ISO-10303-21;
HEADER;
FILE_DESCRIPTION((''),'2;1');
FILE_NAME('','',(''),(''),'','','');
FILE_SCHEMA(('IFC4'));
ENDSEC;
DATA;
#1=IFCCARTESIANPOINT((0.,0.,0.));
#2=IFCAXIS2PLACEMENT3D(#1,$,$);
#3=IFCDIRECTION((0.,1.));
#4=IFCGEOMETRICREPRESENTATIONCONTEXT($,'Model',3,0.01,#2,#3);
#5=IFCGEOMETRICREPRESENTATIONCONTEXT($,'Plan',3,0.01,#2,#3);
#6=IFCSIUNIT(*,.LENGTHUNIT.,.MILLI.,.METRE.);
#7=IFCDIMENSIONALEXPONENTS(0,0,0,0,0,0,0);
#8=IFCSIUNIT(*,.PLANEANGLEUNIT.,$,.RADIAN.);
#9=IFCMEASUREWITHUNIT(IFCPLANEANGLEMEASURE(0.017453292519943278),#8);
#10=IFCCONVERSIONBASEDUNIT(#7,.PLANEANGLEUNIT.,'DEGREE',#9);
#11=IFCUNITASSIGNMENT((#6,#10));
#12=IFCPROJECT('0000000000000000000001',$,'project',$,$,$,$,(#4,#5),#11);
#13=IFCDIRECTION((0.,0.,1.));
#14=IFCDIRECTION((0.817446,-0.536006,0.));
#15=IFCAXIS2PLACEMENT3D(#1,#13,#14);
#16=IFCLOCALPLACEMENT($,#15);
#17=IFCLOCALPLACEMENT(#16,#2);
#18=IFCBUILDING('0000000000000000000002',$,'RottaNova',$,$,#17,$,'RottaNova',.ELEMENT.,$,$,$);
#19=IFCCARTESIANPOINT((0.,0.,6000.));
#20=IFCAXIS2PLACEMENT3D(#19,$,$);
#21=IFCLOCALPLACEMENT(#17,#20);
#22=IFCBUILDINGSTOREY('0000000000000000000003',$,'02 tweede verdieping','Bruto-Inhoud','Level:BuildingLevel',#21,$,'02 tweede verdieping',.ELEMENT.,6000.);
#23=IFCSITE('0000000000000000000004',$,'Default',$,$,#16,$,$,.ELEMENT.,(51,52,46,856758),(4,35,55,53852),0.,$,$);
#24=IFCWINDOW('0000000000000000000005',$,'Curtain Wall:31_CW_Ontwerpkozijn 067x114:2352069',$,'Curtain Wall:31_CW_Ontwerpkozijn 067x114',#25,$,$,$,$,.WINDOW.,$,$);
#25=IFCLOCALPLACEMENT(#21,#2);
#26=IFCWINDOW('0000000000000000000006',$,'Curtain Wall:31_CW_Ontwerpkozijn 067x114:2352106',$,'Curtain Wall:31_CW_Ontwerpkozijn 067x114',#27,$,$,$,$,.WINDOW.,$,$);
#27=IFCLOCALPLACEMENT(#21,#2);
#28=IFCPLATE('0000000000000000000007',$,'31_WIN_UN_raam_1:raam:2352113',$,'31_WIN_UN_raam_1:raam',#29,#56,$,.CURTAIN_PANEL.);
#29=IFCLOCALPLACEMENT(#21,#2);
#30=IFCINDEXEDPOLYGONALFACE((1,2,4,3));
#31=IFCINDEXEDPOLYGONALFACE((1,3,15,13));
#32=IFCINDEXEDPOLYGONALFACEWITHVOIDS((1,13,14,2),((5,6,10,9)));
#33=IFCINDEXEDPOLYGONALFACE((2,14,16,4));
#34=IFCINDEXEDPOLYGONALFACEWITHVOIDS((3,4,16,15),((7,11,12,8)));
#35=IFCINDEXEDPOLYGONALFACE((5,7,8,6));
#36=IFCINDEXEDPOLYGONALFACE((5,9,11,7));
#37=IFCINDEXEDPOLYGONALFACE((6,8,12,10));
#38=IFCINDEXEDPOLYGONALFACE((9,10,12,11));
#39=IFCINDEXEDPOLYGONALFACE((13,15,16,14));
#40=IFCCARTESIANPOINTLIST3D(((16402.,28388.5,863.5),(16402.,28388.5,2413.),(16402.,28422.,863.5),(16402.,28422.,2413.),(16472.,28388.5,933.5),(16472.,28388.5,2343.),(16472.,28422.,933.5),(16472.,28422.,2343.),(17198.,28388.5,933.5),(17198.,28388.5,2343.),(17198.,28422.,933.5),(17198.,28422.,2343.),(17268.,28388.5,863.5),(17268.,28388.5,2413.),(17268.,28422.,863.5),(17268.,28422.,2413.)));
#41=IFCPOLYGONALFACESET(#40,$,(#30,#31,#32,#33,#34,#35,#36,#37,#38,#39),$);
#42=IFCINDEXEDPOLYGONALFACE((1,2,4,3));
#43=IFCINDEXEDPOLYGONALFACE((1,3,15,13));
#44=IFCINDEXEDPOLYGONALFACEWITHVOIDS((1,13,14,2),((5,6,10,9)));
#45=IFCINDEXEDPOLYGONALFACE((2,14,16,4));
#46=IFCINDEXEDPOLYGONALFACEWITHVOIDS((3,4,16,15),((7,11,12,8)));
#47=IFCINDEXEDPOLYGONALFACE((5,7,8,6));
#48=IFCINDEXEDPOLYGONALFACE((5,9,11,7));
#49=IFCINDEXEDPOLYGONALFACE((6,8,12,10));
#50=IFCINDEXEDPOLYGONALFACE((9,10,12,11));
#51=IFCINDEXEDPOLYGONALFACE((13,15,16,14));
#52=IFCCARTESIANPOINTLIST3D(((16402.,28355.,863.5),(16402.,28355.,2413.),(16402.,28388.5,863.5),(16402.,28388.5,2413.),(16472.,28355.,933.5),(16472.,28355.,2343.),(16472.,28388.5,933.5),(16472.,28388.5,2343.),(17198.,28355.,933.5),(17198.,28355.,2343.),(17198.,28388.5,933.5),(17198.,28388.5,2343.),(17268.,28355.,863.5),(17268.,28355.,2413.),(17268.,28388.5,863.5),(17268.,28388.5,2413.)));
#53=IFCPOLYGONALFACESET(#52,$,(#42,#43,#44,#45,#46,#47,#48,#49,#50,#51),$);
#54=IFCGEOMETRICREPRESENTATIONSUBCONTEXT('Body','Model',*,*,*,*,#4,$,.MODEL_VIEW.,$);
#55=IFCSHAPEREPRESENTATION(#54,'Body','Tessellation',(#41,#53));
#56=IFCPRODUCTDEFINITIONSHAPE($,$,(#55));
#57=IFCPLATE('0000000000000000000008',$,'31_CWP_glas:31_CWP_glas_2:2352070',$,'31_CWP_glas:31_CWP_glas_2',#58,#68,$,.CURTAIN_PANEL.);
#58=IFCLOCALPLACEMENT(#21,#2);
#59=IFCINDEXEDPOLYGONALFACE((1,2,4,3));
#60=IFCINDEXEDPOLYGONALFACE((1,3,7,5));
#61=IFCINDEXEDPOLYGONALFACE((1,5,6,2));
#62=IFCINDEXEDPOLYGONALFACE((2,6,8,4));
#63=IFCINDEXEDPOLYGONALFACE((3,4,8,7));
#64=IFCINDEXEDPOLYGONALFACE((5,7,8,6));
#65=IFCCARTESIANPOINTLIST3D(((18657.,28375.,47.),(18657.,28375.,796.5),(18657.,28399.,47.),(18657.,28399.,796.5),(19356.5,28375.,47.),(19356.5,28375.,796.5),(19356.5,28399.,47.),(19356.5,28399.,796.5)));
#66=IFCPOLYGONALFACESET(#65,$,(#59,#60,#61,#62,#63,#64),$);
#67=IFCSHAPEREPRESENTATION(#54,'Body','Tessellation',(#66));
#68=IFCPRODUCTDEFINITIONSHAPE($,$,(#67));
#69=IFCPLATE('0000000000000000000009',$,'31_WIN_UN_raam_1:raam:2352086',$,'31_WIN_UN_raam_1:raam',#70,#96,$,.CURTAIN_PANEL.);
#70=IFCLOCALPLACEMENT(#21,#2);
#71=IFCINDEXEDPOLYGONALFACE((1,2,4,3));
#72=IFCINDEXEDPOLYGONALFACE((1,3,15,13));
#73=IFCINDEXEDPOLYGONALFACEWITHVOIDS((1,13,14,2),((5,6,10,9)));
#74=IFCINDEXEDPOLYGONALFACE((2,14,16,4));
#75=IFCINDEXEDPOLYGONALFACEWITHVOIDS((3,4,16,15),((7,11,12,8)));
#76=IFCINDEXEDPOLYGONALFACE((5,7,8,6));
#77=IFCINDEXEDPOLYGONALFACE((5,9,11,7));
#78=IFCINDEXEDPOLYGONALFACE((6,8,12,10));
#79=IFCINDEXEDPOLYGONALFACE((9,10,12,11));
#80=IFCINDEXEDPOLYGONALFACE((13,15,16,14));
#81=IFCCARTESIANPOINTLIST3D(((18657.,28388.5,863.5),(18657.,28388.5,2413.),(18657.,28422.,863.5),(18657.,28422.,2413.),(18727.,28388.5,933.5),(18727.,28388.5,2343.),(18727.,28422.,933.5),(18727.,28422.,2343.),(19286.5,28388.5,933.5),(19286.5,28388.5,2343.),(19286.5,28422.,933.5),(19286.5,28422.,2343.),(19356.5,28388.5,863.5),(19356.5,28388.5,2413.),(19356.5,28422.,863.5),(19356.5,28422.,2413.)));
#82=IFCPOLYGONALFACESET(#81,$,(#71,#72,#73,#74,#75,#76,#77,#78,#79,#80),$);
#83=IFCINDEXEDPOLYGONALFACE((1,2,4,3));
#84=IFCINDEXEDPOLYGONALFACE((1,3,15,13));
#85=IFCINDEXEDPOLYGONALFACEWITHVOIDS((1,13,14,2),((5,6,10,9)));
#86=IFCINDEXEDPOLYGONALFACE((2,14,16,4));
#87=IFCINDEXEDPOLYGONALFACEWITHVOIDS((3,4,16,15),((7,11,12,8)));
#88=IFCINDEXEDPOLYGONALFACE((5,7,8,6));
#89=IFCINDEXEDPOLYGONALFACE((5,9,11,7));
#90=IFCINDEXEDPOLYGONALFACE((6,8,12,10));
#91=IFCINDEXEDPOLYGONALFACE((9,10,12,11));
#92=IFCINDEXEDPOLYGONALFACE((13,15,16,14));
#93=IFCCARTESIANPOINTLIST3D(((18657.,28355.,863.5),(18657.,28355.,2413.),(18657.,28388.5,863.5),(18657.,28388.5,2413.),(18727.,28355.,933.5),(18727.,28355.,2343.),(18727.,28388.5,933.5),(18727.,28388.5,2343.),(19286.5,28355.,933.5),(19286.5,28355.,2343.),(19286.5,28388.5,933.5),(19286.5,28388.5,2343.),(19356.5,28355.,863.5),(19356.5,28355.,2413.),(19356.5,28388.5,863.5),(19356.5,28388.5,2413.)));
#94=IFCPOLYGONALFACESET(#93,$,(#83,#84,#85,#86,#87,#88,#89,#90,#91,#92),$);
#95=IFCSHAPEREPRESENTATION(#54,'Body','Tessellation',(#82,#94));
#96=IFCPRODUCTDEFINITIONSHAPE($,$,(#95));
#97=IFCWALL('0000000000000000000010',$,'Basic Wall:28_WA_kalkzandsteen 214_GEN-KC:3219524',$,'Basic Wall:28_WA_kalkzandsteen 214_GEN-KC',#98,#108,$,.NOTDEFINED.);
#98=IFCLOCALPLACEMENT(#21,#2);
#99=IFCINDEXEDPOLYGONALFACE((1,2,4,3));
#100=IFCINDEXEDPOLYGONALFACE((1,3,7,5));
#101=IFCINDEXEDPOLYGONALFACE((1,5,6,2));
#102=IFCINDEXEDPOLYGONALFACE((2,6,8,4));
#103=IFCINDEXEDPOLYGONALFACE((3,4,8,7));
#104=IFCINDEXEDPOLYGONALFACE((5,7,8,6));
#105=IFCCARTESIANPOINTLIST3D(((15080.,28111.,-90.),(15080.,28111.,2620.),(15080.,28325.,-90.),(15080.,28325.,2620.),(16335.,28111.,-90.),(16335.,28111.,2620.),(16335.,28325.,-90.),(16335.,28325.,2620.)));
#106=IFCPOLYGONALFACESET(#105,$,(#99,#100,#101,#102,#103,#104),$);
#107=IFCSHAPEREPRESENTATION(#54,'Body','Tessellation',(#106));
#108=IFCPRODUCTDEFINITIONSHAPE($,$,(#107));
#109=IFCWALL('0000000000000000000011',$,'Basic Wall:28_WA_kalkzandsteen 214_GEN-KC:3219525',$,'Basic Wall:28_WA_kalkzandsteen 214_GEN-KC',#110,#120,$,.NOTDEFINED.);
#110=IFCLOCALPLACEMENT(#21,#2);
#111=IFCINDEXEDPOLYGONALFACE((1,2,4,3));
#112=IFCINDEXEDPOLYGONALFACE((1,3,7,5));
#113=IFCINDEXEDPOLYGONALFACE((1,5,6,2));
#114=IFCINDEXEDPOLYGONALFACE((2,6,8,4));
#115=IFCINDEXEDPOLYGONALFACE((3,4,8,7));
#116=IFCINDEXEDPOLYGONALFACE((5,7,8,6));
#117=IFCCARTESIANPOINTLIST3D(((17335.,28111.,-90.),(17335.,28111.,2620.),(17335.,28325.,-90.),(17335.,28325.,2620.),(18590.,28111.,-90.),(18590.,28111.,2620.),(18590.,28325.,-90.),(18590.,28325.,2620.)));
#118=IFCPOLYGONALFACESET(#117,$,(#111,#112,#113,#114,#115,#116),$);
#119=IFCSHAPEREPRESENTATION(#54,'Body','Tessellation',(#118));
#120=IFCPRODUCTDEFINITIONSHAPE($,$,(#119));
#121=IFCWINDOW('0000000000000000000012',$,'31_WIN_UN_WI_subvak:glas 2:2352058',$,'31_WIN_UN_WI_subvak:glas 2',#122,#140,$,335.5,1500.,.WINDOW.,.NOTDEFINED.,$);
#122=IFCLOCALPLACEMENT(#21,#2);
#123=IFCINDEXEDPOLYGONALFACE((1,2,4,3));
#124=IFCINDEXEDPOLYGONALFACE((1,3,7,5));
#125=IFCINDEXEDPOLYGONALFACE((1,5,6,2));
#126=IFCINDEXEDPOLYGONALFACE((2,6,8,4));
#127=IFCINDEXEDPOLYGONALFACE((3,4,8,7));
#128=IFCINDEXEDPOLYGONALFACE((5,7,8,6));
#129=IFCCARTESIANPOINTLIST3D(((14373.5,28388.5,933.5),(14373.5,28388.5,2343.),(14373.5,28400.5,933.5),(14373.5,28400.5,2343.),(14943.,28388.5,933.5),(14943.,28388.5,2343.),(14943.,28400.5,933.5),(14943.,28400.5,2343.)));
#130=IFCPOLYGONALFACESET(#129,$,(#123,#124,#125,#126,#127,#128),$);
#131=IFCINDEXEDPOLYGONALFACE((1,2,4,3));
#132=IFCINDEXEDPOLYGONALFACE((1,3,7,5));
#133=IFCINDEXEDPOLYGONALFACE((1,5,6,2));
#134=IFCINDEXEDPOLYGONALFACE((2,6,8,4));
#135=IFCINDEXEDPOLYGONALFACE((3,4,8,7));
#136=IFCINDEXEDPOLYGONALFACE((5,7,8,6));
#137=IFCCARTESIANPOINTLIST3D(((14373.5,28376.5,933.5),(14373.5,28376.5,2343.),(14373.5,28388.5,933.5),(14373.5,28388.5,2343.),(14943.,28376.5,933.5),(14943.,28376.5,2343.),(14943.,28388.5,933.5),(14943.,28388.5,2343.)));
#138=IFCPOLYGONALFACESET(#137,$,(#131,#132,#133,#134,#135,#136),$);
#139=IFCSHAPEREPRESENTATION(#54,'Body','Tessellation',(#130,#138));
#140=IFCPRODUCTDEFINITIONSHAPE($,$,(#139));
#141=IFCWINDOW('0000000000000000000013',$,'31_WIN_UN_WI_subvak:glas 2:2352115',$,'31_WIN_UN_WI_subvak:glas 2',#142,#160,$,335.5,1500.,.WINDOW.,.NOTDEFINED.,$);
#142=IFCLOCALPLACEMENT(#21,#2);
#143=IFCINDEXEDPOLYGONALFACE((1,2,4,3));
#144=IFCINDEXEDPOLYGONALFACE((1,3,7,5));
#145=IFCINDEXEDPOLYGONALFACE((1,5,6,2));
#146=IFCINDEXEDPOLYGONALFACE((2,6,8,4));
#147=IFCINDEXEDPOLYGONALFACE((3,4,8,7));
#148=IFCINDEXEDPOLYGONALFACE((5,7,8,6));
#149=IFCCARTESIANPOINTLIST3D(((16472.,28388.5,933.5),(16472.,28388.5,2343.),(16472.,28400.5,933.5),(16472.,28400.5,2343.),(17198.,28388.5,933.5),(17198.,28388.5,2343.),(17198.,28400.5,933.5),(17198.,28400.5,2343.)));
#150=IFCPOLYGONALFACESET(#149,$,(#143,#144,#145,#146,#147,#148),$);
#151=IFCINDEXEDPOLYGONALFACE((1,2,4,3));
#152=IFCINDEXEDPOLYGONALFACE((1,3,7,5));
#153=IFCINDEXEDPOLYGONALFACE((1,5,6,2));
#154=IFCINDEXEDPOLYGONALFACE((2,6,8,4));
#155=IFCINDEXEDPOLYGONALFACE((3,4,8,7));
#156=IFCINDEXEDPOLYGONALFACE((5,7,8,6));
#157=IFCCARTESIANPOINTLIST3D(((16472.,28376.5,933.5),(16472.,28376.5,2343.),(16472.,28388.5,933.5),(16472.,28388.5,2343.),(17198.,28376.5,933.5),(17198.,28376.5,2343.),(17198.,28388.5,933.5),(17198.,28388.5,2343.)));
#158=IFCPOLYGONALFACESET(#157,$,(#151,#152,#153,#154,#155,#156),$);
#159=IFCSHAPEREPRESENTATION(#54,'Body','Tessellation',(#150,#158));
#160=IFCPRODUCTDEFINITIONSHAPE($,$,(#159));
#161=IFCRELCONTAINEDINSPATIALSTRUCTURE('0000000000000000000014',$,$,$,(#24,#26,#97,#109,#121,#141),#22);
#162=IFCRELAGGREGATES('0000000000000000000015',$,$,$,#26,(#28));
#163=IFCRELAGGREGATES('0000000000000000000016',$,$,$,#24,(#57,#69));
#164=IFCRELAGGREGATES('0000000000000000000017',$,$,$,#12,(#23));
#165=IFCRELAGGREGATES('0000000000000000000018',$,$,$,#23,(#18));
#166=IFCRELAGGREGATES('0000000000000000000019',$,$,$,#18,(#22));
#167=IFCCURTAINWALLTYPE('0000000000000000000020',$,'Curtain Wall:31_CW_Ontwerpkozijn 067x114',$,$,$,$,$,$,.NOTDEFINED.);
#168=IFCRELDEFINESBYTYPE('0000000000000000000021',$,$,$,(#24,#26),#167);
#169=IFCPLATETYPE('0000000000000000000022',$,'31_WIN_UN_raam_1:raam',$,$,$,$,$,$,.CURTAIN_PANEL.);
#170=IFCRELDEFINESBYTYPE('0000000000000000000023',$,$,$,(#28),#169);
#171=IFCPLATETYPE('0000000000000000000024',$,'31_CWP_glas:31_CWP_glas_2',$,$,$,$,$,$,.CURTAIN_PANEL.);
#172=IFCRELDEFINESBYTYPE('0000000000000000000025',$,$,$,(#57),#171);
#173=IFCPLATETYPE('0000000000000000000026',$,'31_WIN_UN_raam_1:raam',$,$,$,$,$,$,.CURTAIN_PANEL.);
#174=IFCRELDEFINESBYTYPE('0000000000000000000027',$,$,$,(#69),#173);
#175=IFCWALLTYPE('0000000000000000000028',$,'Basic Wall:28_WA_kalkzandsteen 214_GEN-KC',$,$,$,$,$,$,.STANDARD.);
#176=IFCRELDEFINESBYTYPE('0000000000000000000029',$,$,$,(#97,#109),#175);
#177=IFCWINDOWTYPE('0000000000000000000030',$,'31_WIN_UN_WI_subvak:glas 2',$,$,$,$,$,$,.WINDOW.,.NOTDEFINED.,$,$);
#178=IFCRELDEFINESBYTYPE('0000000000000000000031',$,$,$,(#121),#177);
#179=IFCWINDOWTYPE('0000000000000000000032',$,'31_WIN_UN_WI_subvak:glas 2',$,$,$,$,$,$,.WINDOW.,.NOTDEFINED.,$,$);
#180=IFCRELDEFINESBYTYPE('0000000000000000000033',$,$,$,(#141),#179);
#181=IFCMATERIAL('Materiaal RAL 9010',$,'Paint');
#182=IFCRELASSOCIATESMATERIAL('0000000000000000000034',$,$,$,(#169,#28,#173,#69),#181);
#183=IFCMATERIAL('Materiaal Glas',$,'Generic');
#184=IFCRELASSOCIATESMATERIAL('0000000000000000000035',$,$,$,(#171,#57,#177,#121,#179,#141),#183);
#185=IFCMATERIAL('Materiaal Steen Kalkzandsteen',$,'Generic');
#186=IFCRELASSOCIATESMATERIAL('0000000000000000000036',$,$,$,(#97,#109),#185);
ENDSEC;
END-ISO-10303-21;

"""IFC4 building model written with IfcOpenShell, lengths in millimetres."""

from ifc_helpers import new_model, entity, si_unit, converted_unit, direction, frame, origin, place, context, subcontext, project, spatial, indexed_curve, outline, extrude, source, transform, mapped, material, type_object, type_shapes, element, aggregate, save


model = new_model("IFC4")

# Units and contexts
model_context = context("Model", 3, precision=0.01, world=origin(), true_north=direction((0.0, 1.0)))
plan_context = context("Plan", 3, precision=0.01, world=origin(), true_north=direction((0.0, 1.0)))
body_context = subcontext(model_context, "Body", "Model", "MODEL_VIEW")
ifc_project = project(units=[si_unit("LENGTHUNIT", "METRE", prefix="MILLI"), converted_unit("PLANEANGLEUNIT", "DEGREE", entity("IfcPlaneAngleMeasure", 0.017453292519943278), si_unit("PLANEANGLEUNIT", "RADIAN"), dimensions=[0, 0, 0, 0, 0, 0, 0])], contexts=[model_context, plan_context])

# Site, building, storey
site_placement = place(None, frame((0.0, 0.0, 0.0), z_axis=(0.0, 0.0, 1.0), x_axis=(0.817446, -0.536006, 0.0)))
site = spatial("IfcSite", under=ifc_project, at=site_placement, Name="Default", CompositionType="ELEMENT", RefLatitude=(51, 52, 46, 856758), RefLongitude=(4, 35, 55, 53852), RefElevation=0.0)
building_placement = place(site_placement, origin())
building = spatial("IfcBuilding", under=site, at=building_placement, Name="RottaNova", LongName="RottaNova", CompositionType="ELEMENT")
storey_placement = place(building_placement, frame((0.0, 0.0, 6000.0)))
storey = spatial("IfcBuildingStorey", under=building, at=storey_placement, Name="02 tweede verdieping", Description="Bruto-Inhoud", ObjectType="Level:BuildingLevel", LongName="02 tweede verdieping", CompositionType="ELEMENT", Elevation=6000.0)

# Shared definitions
curtain_wall_type = type_object("IfcCurtainWallType", Name="Curtain Wall:31_CW_Ontwerpkozijn 067x114", PredefinedType="NOTDEFINED")

# Window
window_1_placement = place(storey_placement, frame((0.0, 0.0, -6000.0)))
window_1 = element("IfcWindow", 1, at=window_1_placement, inside=storey, type_object=curtain_wall_type, Name="Curtain Wall:31_CW_Ontwerpkozijn 067x114:2352069", ObjectType="Curtain Wall:31_CW_Ontwerpkozijn 067x114", PredefinedType="WINDOW")

# Window
window_2_placement = place(storey_placement, frame((0.0, 0.0, -6000.0)))
window_2 = element("IfcWindow", 2, at=window_2_placement, inside=storey, type_object=curtain_wall_type, Name="Curtain Wall:31_CW_Ontwerpkozijn 067x114:2352106", ObjectType="Curtain Wall:31_CW_Ontwerpkozijn 067x114", PredefinedType="WINDOW")

# Plates
ifc_material_1 = material(Name="Materiaal Glas", Category="Generic")
ifc_material_2 = material(Name="Materiaal RAL 9010", Category="Paint")
plate_type_1 = type_object("IfcPlateType", Name="31_WIN_UN_raam_1:raam", PredefinedType="CURTAIN_PANEL", material=ifc_material_2)
shared_shape_1 = source(origin(), body_context, "Body", "SweptSolid", [
    extrude(outline(indexed_curve([(-433.0, -774.7), (433.0, -774.7), (433.0, 774.7), (-433.0, 774.7), (-433.0, -774.7)], self_intersect=False), holes=[indexed_curve([(-363.0, 704.7), (363.0, 704.7), (363.0, -704.8), (-363.0, -704.8), (-363.0, 704.7)], self_intersect=False)]), frame((0.0, -92.0, 774.8), z_axis=(0.0, 1.0, 0.0), x_axis=(1.0, 0.0, 0.0)), (0.0, 0.0, 1.0), 33.5),
    extrude(outline(indexed_curve([(-433.0, -774.7), (433.0, -774.7), (433.0, 774.7), (-433.0, 774.7), (-433.0, -774.7)], self_intersect=False), holes=[indexed_curve([(-363.0, 704.7), (363.0, 704.7), (363.0, -704.8), (-363.0, -704.8), (-363.0, 704.7)], self_intersect=False)]), frame((0.0, -58.5, 774.8), z_axis=(0.0, 1.0, 0.0), x_axis=(1.0, 0.0, 0.0)), (0.0, 0.0, 1.0), 33.5),
])
type_shapes(plate_type_1, [shared_shape_1])
plate_1_placement = place(window_2_placement, frame((16835.0, 28330.0, 6863.5), z_axis=(0.0, 0.0, 1.0), x_axis=(-1.0, 0.0, 0.0)))
plate_1 = element("IfcPlate", 3, at=plate_1_placement, type_object=plate_type_1, material=ifc_material_2, Name="31_WIN_UN_raam_1:raam:2352113", ObjectType="31_WIN_UN_raam_1:raam", PredefinedType="CURTAIN_PANEL", context=body_context, shape_type="MappedRepresentation", body=[
    mapped(shared_shape_1, transform((0.0, 0.0, 0.0), scale=1.0)),
])
aggregate(window_2, [plate_1])
plate_type_2 = type_object("IfcPlateType", Name="31_CWP_glas:31_CWP_glas_2", PredefinedType="CURTAIN_PANEL", material=ifc_material_1)
shared_shape_2 = source(origin(), body_context, "Body", "SweptSolid", [
    extrude(outline(indexed_curve([(-12.0, -349.8), (12.0, -349.8), (12.0, 349.8), (-12.0, 349.8), (-12.0, -349.8)], self_intersect=False)), frame((0.0, 57.0, 0.0), z_axis=(0.0, 0.0, 1.0), x_axis=(0.0, 1.0, 0.0)), (0.0, 0.0, 1.0), 749.5),
])
type_shapes(plate_type_2, [shared_shape_2])
plate_2_placement = place(window_1_placement, frame((19006.8, 28330.0, 6047.0)))
plate_2 = element("IfcPlate", 4, at=plate_2_placement, type_object=plate_type_2, material=ifc_material_1, Name="31_CWP_glas:31_CWP_glas_2:2352070", ObjectType="31_CWP_glas:31_CWP_glas_2", PredefinedType="CURTAIN_PANEL", context=body_context, shape_type="MappedRepresentation", body=[
    mapped(shared_shape_2, transform((0.0, 0.0, 0.0), scale=1.0)),
])
plate_type_3 = type_object("IfcPlateType", Name="31_WIN_UN_raam_1:raam", PredefinedType="CURTAIN_PANEL", material=ifc_material_2)
shared_shape_3 = source(origin(), body_context, "Body", "SweptSolid", [
    extrude(outline(indexed_curve([(-349.7, -774.8), (349.7, -774.8), (349.7, 774.8), (-349.7, 774.8), (-349.7, -774.8)], self_intersect=False), holes=[indexed_curve([(-279.7, 704.8), (279.7, 704.8), (279.7, -704.8), (-279.7, -704.8), (-279.7, 704.8)], self_intersect=False)]), frame((0.0, 58.5, 774.8), z_axis=(0.0, 1.0, 0.0), x_axis=(1.0, 0.0, 0.0)), (0.0, 0.0, 1.0), 33.5),
    extrude(outline(indexed_curve([(-349.7, -774.8), (349.7, -774.8), (349.7, 774.8), (-349.7, 774.8), (-349.7, -774.8)], self_intersect=False), holes=[indexed_curve([(-279.7, 704.7), (279.7, 704.7), (279.7, -704.8), (-279.7, -704.8), (-279.7, 704.7)], self_intersect=False)]), frame((0.0, 25.0, 774.8), z_axis=(0.0, 1.0, 0.0), x_axis=(1.0, 0.0, 0.0)), (0.0, 0.0, 1.0), 33.5),
])
type_shapes(plate_type_3, [shared_shape_3])
plate_3_placement = place(window_1_placement, frame((19006.8, 28330.0, 6863.5)))
plate_3 = element("IfcPlate", 5, at=plate_3_placement, type_object=plate_type_3, material=ifc_material_2, Name="31_WIN_UN_raam_1:raam:2352086", ObjectType="31_WIN_UN_raam_1:raam", PredefinedType="CURTAIN_PANEL", context=body_context, shape_type="MappedRepresentation", body=[
    mapped(shared_shape_3, transform((0.0, 0.0, 0.0), scale=1.0)),
])
aggregate(window_1, [plate_2, plate_3])

# Walls
ifc_material_3 = material(Name="Materiaal Steen Kalkzandsteen", Category="Generic")
wall_type = type_object("IfcWallType", Name="Basic Wall:28_WA_kalkzandsteen 214_GEN-KC", PredefinedType="STANDARD")
wall_1_placement = place(storey_placement, frame((15080.0, 28218.0, -90.0)))
element("IfcWall", 6, at=wall_1_placement, inside=storey, type_object=wall_type, material=ifc_material_3, Name="Basic Wall:28_WA_kalkzandsteen 214_GEN-KC:3219524", ObjectType="Basic Wall:28_WA_kalkzandsteen 214_GEN-KC", PredefinedType="NOTDEFINED", context=body_context, shape_type="SweptSolid", body=[
    extrude(outline(indexed_curve([(1255.0, 107.0), (0.0, 107.0), (0.0, -107.0), (1255.0, -107.0), (1255.0, 107.0)], self_intersect=False)), origin(), (0.0, 0.0, 1.0), 2710.0),
])
wall_2_placement = place(storey_placement, frame((17335.0, 28218.0, -90.0)))
element("IfcWall", 7, at=wall_2_placement, inside=storey, type_object=wall_type, material=ifc_material_3, Name="Basic Wall:28_WA_kalkzandsteen 214_GEN-KC:3219525", ObjectType="Basic Wall:28_WA_kalkzandsteen 214_GEN-KC", PredefinedType="NOTDEFINED", context=body_context, shape_type="SweptSolid", body=[
    extrude(outline(indexed_curve([(1255.0, 107.0), (0.0, 107.0), (0.0, -107.0), (1255.0, -107.0), (1255.0, 107.0)], self_intersect=False)), origin(), (0.0, 0.0, 1.0), 2710.0),
])

# Windows
window_type_1 = type_object("IfcWindowType", Name="31_WIN_UN_WI_subvak:glas 2", PartitioningType="NOTDEFINED", PredefinedType="WINDOW", material=ifc_material_1)
shared_shape_4 = source(origin(), body_context, "Body", "SweptSolid", [
    extrude(outline(indexed_curve([(-6.0, -284.7), (6.0, -284.7), (6.0, 284.7), (-6.0, 284.7), (-6.0, -284.7)], self_intersect=False)), frame((0.0, 6.0, 0.0), z_axis=(0.0, 0.0, 1.0), x_axis=(0.0, -1.0, 0.0)), (0.0, 0.0, 1.0), 1409.5),
    extrude(outline(indexed_curve([(-6.0, -284.8), (6.0, -284.8), (6.0, 284.8), (-6.0, 284.8), (-6.0, -284.8)], self_intersect=False)), frame((0.0, -6.0, 0.0), z_axis=(0.0, 0.0, 1.0), x_axis=(0.0, -1.0, 0.0)), (0.0, 0.0, 1.0), 1409.5),
])
type_shapes(window_type_1, [shared_shape_4])
window_3_placement = place(storey_placement, frame((14658.3, 28388.5, 933.5)))
element("IfcWindow", 8, at=window_3_placement, inside=storey, type_object=window_type_1, material=ifc_material_1, Name="31_WIN_UN_WI_subvak:glas 2:2352058", ObjectType="31_WIN_UN_WI_subvak:glas 2", OverallHeight=335.5, OverallWidth=1500.0, PartitioningType="NOTDEFINED", PredefinedType="WINDOW", context=body_context, shape_type="MappedRepresentation", body=[
    mapped(shared_shape_4, transform((0.0, 0.0, 0.0), scale=1.0)),
])
window_type_2 = type_object("IfcWindowType", Name="31_WIN_UN_WI_subvak:glas 2", PartitioningType="NOTDEFINED", PredefinedType="WINDOW", material=ifc_material_1)
shared_shape_5 = source(origin(), body_context, "Body", "SweptSolid", [
    extrude(outline(indexed_curve([(-363.0, -6.0), (363.0, -6.0), (363.0, 6.0), (-363.0, 6.0), (-363.0, -6.0)], self_intersect=False)), frame((0.0, -6.0, 0.0)), (0.0, 0.0, 1.0), 1409.5),
    extrude(outline(indexed_curve([(-363.0, -6.0), (363.0, -6.0), (363.0, 6.0), (-363.0, 6.0), (-363.0, -6.0)], self_intersect=False)), frame((0.0, 6.0, 0.0)), (0.0, 0.0, 1.0), 1409.5),
])
type_shapes(window_type_2, [shared_shape_5])
window_4_placement = place(storey_placement, frame((16835.0, 28388.5, 933.5), z_axis=(0.0, 0.0, 1.0), x_axis=(-1.0, 0.0, 0.0)))
element("IfcWindow", 9, at=window_4_placement, inside=storey, type_object=window_type_2, material=ifc_material_1, Name="31_WIN_UN_WI_subvak:glas 2:2352115", ObjectType="31_WIN_UN_WI_subvak:glas 2", OverallHeight=335.5, OverallWidth=1500.0, PartitioningType="NOTDEFINED", PredefinedType="WINDOW", context=body_context, shape_type="MappedRepresentation", body=[
    mapped(shared_shape_5, transform((0.0, 0.0, 0.0), scale=1.0)),
])

save(model, "model.ifc")
